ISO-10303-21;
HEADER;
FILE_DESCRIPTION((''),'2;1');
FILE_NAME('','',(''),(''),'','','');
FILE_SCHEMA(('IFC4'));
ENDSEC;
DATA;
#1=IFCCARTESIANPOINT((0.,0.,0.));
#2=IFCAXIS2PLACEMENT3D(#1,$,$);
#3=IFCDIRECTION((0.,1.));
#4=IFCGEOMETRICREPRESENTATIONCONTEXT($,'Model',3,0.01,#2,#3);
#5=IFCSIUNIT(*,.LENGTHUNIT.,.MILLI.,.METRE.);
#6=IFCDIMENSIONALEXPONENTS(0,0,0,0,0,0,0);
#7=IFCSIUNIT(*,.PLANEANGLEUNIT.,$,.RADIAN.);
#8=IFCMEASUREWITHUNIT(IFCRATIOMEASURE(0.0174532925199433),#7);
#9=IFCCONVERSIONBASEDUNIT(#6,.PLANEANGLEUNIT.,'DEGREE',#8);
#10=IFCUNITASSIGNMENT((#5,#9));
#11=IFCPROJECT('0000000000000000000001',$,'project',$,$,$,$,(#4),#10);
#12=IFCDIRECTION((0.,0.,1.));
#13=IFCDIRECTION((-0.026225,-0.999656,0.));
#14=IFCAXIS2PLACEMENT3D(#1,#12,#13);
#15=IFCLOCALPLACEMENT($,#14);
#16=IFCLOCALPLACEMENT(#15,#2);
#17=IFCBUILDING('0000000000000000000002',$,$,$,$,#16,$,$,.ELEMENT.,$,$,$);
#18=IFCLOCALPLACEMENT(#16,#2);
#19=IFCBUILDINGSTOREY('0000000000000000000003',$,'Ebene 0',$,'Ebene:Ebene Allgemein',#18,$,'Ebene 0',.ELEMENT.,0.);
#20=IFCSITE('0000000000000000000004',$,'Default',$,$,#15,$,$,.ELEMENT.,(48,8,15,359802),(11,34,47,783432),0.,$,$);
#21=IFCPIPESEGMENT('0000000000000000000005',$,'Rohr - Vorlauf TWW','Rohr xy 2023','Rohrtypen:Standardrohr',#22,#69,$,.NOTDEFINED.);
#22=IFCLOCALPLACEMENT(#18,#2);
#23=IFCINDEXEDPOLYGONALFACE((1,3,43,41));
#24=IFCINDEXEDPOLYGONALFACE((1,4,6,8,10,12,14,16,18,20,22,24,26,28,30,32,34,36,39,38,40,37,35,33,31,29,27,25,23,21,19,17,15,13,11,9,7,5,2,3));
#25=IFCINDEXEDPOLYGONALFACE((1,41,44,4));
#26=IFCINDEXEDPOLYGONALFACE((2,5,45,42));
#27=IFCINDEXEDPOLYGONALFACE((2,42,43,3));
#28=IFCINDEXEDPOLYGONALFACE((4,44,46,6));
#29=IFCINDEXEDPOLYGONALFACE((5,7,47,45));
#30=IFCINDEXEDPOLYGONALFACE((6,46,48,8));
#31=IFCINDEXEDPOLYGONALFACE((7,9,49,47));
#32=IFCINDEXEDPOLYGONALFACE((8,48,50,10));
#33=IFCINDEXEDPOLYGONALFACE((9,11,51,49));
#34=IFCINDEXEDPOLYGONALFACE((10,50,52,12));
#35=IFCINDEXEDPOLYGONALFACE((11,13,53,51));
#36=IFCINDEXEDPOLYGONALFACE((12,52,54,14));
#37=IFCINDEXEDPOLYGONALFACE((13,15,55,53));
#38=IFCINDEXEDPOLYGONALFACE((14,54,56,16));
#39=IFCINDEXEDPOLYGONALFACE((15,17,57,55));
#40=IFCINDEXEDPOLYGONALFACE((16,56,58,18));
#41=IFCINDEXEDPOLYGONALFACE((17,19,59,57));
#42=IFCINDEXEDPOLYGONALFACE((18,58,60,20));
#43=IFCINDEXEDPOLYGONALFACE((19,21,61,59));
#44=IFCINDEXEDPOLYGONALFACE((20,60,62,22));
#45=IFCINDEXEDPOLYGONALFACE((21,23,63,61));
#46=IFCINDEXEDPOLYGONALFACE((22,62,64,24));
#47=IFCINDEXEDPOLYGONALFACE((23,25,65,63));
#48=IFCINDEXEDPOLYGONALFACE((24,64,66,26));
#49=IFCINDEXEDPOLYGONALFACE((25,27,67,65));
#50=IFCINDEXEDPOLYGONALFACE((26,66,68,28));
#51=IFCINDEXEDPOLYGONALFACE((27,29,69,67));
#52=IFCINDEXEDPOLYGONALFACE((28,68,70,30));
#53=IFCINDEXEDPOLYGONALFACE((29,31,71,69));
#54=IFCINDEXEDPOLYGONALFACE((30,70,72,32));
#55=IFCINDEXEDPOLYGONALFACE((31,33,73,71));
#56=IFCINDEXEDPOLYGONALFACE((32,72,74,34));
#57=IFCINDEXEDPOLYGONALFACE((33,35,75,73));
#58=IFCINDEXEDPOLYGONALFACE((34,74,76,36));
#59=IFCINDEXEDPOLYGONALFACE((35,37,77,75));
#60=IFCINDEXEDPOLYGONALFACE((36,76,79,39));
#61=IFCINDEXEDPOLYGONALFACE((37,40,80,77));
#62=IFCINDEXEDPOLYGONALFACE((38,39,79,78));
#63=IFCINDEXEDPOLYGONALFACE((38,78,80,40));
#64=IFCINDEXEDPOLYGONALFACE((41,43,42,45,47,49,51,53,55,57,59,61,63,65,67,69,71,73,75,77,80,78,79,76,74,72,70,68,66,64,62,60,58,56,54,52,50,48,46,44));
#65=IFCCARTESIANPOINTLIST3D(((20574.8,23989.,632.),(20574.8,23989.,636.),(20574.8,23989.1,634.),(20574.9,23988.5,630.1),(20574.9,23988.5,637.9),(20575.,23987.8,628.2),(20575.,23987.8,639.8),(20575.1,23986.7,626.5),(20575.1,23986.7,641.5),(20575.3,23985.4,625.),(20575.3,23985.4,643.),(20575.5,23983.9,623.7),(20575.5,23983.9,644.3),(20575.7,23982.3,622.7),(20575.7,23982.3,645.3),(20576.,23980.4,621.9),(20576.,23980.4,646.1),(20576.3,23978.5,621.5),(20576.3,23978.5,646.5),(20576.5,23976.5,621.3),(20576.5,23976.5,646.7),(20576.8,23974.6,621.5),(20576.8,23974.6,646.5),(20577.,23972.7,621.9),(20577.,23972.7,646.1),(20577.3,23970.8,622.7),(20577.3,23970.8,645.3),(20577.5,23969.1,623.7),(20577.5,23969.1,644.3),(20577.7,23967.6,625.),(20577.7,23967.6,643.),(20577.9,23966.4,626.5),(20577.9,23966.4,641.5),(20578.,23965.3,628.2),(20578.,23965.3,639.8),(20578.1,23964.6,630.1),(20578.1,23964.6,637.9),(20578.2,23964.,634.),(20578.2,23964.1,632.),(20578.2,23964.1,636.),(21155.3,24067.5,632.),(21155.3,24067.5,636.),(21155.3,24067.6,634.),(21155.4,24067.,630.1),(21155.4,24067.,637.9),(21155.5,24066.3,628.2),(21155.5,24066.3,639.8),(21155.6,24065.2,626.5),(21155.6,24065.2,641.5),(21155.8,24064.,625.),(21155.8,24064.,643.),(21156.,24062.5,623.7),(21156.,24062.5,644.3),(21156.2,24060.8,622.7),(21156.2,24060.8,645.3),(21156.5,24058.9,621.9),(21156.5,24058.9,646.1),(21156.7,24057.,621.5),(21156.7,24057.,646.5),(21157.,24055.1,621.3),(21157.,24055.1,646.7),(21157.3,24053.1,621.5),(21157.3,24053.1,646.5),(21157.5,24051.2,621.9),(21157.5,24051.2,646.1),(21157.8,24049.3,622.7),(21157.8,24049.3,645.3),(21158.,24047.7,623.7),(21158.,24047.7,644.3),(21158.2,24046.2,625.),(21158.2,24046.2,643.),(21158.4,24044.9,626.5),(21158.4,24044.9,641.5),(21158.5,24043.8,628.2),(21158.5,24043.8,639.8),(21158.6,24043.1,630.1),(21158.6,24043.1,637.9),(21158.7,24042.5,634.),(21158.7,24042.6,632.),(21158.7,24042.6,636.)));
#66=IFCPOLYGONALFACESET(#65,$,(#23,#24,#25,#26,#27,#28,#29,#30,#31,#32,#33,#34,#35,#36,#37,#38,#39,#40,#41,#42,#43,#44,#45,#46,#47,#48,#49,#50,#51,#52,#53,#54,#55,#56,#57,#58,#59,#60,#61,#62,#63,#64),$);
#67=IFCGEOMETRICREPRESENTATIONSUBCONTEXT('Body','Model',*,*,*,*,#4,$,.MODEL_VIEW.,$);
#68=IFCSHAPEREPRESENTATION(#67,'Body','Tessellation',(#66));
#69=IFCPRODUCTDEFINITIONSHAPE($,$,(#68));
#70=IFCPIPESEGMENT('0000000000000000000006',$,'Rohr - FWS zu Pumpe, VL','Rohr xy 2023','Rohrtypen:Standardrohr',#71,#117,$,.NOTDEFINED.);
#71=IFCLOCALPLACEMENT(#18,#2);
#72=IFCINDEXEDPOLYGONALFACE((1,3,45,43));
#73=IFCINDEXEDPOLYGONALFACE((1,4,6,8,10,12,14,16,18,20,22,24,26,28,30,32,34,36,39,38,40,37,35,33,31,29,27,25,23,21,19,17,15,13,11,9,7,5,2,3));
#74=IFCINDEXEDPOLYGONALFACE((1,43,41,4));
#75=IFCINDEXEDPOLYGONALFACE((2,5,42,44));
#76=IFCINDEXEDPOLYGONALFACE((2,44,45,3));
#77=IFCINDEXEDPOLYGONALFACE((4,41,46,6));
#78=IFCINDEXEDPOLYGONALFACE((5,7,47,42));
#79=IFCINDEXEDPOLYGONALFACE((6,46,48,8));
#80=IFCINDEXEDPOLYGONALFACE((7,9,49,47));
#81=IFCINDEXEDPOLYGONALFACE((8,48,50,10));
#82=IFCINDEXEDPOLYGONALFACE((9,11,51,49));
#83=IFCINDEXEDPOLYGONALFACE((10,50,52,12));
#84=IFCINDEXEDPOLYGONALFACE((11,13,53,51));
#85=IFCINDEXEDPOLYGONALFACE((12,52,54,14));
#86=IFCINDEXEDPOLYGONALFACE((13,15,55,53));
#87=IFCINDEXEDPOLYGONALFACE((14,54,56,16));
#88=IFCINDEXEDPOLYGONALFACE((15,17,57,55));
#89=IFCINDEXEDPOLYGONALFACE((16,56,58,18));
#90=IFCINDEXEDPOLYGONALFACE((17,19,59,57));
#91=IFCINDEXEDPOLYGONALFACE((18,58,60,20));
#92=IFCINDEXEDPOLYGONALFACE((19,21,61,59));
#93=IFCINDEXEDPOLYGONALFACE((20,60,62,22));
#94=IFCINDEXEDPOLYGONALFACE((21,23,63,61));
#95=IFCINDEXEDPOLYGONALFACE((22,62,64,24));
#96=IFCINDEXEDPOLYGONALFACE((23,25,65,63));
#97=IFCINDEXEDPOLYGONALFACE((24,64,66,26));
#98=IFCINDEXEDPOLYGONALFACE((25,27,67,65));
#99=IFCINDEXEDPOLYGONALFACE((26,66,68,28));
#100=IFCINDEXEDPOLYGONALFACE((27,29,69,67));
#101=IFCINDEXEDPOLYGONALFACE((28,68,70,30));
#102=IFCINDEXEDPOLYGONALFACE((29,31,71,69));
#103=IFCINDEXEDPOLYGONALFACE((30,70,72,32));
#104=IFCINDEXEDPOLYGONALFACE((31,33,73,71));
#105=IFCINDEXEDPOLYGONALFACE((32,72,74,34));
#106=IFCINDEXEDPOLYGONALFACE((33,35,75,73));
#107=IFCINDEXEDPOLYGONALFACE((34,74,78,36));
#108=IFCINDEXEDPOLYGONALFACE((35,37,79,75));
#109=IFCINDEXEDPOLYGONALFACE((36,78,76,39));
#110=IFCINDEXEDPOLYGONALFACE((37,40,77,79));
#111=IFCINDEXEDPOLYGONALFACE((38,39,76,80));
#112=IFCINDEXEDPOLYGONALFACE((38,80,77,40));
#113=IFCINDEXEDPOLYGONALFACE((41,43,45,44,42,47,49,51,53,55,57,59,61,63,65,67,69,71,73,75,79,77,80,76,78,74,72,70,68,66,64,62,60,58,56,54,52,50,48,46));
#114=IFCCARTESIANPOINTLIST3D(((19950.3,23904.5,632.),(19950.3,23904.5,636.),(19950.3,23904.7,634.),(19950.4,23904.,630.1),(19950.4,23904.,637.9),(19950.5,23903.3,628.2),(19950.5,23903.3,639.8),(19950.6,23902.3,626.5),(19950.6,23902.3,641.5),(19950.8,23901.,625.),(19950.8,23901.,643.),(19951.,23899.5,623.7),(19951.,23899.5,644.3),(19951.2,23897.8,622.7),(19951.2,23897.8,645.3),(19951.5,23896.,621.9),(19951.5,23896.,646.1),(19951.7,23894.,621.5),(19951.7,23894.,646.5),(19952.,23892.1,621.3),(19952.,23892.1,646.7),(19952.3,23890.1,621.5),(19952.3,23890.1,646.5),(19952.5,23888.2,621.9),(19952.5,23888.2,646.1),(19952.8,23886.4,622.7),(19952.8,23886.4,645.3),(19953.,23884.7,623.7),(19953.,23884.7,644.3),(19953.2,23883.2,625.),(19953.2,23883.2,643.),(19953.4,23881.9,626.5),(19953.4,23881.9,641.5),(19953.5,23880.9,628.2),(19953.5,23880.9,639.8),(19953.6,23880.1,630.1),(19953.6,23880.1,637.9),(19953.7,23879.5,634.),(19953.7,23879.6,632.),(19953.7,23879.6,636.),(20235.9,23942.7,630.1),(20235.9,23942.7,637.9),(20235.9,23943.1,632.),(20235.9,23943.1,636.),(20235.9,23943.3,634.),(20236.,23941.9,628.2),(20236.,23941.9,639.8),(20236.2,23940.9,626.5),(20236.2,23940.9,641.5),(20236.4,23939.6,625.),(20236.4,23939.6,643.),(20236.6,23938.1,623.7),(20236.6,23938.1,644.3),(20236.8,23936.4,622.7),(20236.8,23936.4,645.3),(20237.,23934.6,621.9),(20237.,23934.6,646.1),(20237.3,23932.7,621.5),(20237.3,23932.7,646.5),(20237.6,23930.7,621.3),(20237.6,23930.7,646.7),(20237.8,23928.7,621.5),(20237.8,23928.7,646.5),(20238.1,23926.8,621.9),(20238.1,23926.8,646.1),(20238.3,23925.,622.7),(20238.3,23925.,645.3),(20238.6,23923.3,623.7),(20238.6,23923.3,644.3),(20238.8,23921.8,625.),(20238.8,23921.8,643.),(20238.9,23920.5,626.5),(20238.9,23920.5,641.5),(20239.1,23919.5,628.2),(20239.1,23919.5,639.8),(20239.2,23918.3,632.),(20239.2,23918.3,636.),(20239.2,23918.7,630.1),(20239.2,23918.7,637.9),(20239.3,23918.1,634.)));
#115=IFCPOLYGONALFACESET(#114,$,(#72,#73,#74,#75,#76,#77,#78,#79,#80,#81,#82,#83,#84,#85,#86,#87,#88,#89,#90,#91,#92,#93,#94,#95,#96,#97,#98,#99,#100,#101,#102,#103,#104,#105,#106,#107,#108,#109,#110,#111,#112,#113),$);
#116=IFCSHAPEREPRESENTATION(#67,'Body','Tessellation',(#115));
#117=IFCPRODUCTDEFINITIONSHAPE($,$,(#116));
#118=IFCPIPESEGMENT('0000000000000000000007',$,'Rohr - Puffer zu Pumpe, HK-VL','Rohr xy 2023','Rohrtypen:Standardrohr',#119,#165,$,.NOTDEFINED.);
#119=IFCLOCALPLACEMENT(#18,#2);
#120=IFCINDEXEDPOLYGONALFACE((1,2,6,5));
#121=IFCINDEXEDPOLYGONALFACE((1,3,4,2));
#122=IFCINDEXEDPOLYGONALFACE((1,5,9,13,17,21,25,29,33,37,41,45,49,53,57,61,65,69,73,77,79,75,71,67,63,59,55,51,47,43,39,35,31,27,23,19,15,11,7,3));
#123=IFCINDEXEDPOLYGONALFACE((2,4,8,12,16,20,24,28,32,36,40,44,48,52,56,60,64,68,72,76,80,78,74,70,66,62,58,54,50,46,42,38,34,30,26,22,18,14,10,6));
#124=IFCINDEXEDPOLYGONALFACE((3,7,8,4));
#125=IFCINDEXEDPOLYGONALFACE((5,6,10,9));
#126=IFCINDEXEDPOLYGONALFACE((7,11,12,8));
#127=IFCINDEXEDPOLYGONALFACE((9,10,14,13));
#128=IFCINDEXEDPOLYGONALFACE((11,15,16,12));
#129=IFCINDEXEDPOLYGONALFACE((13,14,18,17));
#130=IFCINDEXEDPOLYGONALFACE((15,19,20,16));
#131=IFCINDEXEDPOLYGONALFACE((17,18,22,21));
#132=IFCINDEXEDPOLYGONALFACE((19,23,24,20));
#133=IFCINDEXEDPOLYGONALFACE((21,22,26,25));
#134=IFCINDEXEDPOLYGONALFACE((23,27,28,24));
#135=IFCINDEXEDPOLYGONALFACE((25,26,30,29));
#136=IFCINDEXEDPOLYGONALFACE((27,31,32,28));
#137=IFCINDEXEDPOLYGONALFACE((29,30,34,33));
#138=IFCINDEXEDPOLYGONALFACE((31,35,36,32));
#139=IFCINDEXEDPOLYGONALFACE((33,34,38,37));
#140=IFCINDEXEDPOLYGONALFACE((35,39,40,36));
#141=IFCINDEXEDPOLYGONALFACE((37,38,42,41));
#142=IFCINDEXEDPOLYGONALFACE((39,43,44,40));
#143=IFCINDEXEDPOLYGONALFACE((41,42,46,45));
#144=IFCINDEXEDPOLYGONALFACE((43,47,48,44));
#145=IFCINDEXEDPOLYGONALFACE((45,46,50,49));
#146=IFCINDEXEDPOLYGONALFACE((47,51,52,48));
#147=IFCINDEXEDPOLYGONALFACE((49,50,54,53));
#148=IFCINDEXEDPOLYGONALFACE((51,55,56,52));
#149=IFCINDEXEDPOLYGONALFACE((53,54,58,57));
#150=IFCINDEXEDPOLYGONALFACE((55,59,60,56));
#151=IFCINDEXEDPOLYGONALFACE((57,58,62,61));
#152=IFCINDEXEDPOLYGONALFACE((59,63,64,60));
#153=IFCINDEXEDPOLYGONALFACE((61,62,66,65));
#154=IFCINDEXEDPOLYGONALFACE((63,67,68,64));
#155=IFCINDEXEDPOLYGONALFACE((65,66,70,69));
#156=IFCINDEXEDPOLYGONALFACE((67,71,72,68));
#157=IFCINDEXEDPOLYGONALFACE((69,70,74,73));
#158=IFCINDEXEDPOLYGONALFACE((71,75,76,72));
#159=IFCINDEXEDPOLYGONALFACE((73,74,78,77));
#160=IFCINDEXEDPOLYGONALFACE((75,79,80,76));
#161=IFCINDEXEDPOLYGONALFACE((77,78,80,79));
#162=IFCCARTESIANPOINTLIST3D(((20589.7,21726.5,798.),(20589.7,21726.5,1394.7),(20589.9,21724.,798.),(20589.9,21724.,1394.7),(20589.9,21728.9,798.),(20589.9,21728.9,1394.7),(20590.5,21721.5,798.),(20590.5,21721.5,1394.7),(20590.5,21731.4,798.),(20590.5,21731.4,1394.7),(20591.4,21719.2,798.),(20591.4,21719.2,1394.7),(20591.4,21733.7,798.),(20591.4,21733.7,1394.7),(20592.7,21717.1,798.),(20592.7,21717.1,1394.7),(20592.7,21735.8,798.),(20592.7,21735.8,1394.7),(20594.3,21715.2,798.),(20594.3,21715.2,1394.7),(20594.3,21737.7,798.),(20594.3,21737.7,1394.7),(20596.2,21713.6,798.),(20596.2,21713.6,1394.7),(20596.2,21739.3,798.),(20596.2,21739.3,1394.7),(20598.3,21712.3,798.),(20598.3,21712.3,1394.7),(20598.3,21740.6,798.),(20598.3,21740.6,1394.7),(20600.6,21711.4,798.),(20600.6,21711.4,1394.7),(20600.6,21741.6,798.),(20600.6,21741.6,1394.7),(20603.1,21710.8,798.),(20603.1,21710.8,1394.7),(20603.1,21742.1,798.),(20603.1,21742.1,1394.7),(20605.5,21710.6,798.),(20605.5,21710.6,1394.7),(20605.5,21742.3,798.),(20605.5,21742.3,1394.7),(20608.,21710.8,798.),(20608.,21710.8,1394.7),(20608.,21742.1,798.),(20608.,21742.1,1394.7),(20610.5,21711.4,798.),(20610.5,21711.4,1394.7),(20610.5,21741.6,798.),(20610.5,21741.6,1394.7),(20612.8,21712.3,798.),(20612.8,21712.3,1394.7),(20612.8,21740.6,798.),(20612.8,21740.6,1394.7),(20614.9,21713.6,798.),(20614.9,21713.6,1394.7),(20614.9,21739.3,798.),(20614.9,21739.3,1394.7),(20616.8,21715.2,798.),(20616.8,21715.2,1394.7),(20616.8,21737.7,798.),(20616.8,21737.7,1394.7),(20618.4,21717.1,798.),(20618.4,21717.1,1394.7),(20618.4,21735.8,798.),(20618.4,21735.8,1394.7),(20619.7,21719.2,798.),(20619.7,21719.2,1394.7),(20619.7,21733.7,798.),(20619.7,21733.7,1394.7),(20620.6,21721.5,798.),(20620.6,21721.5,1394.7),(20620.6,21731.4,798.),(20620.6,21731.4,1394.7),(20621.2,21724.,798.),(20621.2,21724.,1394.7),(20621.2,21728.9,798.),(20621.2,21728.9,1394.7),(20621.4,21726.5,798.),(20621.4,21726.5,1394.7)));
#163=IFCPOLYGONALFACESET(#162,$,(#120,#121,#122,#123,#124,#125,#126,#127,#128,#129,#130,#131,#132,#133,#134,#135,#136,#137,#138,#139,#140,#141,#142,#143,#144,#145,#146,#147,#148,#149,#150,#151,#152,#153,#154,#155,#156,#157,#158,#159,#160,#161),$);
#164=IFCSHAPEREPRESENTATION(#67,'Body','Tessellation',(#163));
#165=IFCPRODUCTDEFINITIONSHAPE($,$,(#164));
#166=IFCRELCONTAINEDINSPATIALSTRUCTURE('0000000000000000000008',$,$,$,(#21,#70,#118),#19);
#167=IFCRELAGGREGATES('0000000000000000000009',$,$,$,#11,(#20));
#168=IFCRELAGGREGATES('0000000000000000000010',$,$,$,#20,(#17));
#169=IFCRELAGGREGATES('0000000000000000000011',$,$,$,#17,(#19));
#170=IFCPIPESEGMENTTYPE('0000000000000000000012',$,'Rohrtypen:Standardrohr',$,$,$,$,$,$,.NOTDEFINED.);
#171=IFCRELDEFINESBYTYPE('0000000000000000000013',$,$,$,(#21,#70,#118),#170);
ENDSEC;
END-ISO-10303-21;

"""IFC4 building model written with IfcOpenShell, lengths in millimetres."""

from ifc_helpers import new_model, entity, si_unit, converted_unit, direction, frame, origin, place, context, subcontext, project, spatial, indexed_curve, outline, extrude, type_object, element, save


model = new_model("IFC4")

# Units and contexts
model_context = context("Model", 3, precision=0.01, world=origin(), true_north=direction((0.0, 1.0)))
body_context = subcontext(model_context, "Body", "Model", "MODEL_VIEW")
ifc_project = project(units=[si_unit("LENGTHUNIT", "METRE", prefix="MILLI"), converted_unit("PLANEANGLEUNIT", "DEGREE", entity("IfcRatioMeasure", 0.0174532925199433), si_unit("PLANEANGLEUNIT", "RADIAN"), dimensions=[0, 0, 0, 0, 0, 0, 0])], contexts=[model_context])

# Site, building, storey
site_placement = place(None, frame((0.0, 0.0, 0.0), z_axis=(0.0, 0.0, 1.0), x_axis=(-0.026225, -0.999656, 0.0)))
site = spatial("IfcSite", under=ifc_project, at=site_placement, Name="Default", CompositionType="ELEMENT", RefLatitude=(48, 8, 15, 359802), RefLongitude=(11, 34, 47, 783432), RefElevation=0.0)
building_placement = place(site_placement, origin())
building = spatial("IfcBuilding", under=site, at=building_placement, CompositionType="ELEMENT")
storey_placement = place(building_placement, origin())
storey = spatial("IfcBuildingStorey", under=building, at=storey_placement, Name="Ebene 0", ObjectType="Ebene:Ebene Allgemein", LongName="Ebene 0", CompositionType="ELEMENT", Elevation=0.0)

# Pipe segments
pipe_segment_type = type_object("IfcPipeSegmentType", Name="Rohrtypen:Standardrohr", PredefinedType="NOTDEFINED")
pipe_segment_1_placement = place(storey_placement, origin())
element("IfcPipeSegment", 1, at=pipe_segment_1_placement, inside=storey, type_object=pipe_segment_type, Name="Rohr - Vorlauf TWW", Description="Rohr xy 2023", ObjectType="Rohrtypen:Standardrohr", PredefinedType="NOTDEFINED", context=body_context, shape_type="SweptSolid", body=[
    extrude(outline(indexed_curve([(12.7, 0.0), (12.5, 2.0), (12.1, 3.9), (11.3, 5.8), (10.3, 7.5), (9.0, 9.0), (7.5, 10.3), (5.8, 11.3), (3.9, 12.1), (2.0, 12.5), (0.0, 12.7), (-2.0, 12.5), (-3.9, 12.1), (-5.8, 11.3), (-7.5, 10.3), (-9.0, 9.0), (-10.3, 7.5), (-11.3, 5.8), (-12.1, 3.9), (-12.5, 2.0), (-12.7, 0.0), (-12.5, -2.0), (-12.1, -3.9), (-11.3, -5.8), (-10.3, -7.5), (-9.0, -9.0), (-7.5, -10.3), (-5.8, -11.3), (-3.9, -12.1), (-2.0, -12.5), (0.0, -12.7), (2.0, -12.5), (3.9, -12.1), (5.8, -11.3), (7.5, -10.3), (9.0, -9.0), (10.3, -7.5), (11.3, -5.8), (12.1, -3.9), (12.5, -2.0), (12.7, 0.0)], self_intersect=False)), frame((20576.5, 23976.5, 634.0), z_axis=(0.990977, 0.134035, 0.0), x_axis=(0.134035, -0.990977, 0.0)), (0.0, 0.0, 1.0), 585.8),
])
pipe_segment_2_placement = place(storey_placement, origin())
element("IfcPipeSegment", 2, at=pipe_segment_2_placement, inside=storey, type_object=pipe_segment_type, Name="Rohr - FWS zu Pumpe, VL", Description="Rohr xy 2023", ObjectType="Rohrtypen:Standardrohr", PredefinedType="NOTDEFINED", context=body_context, shape_type="SweptSolid", body=[
    extrude(outline(indexed_curve([(12.7, 0.0), (12.5, 2.0), (12.1, 3.9), (11.3, 5.8), (10.3, 7.5), (9.0, 9.0), (7.5, 10.3), (5.8, 11.3), (3.9, 12.1), (2.0, 12.5), (0.0, 12.7), (-2.0, 12.5), (-3.9, 12.1), (-5.8, 11.3), (-7.5, 10.3), (-9.0, 9.0), (-10.3, 7.5), (-11.3, 5.8), (-12.1, 3.9), (-12.5, 2.0), (-12.7, 0.0), (-12.5, -2.0), (-12.1, -3.9), (-11.3, -5.8), (-10.3, -7.5), (-9.0, -9.0), (-7.5, -10.3), (-5.8, -11.3), (-3.9, -12.1), (-2.0, -12.5), (0.0, -12.7), (2.0, -12.5), (3.9, -12.1), (5.8, -11.3), (7.5, -10.3), (9.0, -9.0), (10.3, -7.5), (11.3, -5.8), (12.1, -3.9), (12.5, -2.0), (12.7, 0.0)], self_intersect=False)), frame((19952.0, 23892.1, 634.0), z_axis=(0.990977, 0.134035, 0.0), x_axis=(0.134035, -0.990977, 0.0)), (0.0, 0.0, 1.0), 288.2),
])
pipe_segment_3_placement = place(storey_placement, origin())
element("IfcPipeSegment", 3, at=pipe_segment_3_placement, inside=storey, type_object=pipe_segment_type, Name="Rohr - Puffer zu Pumpe, HK-VL", Description="Rohr xy 2023", ObjectType="Rohrtypen:Standardrohr", PredefinedType="NOTDEFINED", context=body_context, shape_type="SweptSolid", body=[
    extrude(outline(indexed_curve([(15.9, 0.0), (15.7, 2.5), (15.1, 4.9), (14.1, 7.2), (12.8, 9.3), (11.2, 11.2), (9.3, 12.8), (7.2, 14.1), (4.9, 15.1), (2.5, 15.7), (0.0, 15.9), (-2.5, 15.7), (-4.9, 15.1), (-7.2, 14.1), (-9.3, 12.8), (-11.2, 11.2), (-12.8, 9.3), (-14.1, 7.2), (-15.1, 4.9), (-15.7, 2.5), (-15.9, 0.0), (-15.7, -2.5), (-15.1, -4.9), (-14.1, -7.2), (-12.8, -9.3), (-11.2, -11.2), (-9.3, -12.8), (-7.2, -14.1), (-4.9, -15.1), (-2.5, -15.7), (0.0, -15.9), (2.5, -15.7), (4.9, -15.1), (7.2, -14.1), (9.3, -12.8), (11.2, -11.2), (12.8, -9.3), (14.1, -7.2), (15.1, -4.9), (15.7, -2.5), (15.9, 0.0)], self_intersect=False)), frame((20605.5, 21726.5, 798.0), z_axis=(0.0, 0.0, 1.0), x_axis=(-1.0, 0.0, 0.0)), (0.0, 0.0, 1.0), 596.7),
])

save(model, "model.ifc")
